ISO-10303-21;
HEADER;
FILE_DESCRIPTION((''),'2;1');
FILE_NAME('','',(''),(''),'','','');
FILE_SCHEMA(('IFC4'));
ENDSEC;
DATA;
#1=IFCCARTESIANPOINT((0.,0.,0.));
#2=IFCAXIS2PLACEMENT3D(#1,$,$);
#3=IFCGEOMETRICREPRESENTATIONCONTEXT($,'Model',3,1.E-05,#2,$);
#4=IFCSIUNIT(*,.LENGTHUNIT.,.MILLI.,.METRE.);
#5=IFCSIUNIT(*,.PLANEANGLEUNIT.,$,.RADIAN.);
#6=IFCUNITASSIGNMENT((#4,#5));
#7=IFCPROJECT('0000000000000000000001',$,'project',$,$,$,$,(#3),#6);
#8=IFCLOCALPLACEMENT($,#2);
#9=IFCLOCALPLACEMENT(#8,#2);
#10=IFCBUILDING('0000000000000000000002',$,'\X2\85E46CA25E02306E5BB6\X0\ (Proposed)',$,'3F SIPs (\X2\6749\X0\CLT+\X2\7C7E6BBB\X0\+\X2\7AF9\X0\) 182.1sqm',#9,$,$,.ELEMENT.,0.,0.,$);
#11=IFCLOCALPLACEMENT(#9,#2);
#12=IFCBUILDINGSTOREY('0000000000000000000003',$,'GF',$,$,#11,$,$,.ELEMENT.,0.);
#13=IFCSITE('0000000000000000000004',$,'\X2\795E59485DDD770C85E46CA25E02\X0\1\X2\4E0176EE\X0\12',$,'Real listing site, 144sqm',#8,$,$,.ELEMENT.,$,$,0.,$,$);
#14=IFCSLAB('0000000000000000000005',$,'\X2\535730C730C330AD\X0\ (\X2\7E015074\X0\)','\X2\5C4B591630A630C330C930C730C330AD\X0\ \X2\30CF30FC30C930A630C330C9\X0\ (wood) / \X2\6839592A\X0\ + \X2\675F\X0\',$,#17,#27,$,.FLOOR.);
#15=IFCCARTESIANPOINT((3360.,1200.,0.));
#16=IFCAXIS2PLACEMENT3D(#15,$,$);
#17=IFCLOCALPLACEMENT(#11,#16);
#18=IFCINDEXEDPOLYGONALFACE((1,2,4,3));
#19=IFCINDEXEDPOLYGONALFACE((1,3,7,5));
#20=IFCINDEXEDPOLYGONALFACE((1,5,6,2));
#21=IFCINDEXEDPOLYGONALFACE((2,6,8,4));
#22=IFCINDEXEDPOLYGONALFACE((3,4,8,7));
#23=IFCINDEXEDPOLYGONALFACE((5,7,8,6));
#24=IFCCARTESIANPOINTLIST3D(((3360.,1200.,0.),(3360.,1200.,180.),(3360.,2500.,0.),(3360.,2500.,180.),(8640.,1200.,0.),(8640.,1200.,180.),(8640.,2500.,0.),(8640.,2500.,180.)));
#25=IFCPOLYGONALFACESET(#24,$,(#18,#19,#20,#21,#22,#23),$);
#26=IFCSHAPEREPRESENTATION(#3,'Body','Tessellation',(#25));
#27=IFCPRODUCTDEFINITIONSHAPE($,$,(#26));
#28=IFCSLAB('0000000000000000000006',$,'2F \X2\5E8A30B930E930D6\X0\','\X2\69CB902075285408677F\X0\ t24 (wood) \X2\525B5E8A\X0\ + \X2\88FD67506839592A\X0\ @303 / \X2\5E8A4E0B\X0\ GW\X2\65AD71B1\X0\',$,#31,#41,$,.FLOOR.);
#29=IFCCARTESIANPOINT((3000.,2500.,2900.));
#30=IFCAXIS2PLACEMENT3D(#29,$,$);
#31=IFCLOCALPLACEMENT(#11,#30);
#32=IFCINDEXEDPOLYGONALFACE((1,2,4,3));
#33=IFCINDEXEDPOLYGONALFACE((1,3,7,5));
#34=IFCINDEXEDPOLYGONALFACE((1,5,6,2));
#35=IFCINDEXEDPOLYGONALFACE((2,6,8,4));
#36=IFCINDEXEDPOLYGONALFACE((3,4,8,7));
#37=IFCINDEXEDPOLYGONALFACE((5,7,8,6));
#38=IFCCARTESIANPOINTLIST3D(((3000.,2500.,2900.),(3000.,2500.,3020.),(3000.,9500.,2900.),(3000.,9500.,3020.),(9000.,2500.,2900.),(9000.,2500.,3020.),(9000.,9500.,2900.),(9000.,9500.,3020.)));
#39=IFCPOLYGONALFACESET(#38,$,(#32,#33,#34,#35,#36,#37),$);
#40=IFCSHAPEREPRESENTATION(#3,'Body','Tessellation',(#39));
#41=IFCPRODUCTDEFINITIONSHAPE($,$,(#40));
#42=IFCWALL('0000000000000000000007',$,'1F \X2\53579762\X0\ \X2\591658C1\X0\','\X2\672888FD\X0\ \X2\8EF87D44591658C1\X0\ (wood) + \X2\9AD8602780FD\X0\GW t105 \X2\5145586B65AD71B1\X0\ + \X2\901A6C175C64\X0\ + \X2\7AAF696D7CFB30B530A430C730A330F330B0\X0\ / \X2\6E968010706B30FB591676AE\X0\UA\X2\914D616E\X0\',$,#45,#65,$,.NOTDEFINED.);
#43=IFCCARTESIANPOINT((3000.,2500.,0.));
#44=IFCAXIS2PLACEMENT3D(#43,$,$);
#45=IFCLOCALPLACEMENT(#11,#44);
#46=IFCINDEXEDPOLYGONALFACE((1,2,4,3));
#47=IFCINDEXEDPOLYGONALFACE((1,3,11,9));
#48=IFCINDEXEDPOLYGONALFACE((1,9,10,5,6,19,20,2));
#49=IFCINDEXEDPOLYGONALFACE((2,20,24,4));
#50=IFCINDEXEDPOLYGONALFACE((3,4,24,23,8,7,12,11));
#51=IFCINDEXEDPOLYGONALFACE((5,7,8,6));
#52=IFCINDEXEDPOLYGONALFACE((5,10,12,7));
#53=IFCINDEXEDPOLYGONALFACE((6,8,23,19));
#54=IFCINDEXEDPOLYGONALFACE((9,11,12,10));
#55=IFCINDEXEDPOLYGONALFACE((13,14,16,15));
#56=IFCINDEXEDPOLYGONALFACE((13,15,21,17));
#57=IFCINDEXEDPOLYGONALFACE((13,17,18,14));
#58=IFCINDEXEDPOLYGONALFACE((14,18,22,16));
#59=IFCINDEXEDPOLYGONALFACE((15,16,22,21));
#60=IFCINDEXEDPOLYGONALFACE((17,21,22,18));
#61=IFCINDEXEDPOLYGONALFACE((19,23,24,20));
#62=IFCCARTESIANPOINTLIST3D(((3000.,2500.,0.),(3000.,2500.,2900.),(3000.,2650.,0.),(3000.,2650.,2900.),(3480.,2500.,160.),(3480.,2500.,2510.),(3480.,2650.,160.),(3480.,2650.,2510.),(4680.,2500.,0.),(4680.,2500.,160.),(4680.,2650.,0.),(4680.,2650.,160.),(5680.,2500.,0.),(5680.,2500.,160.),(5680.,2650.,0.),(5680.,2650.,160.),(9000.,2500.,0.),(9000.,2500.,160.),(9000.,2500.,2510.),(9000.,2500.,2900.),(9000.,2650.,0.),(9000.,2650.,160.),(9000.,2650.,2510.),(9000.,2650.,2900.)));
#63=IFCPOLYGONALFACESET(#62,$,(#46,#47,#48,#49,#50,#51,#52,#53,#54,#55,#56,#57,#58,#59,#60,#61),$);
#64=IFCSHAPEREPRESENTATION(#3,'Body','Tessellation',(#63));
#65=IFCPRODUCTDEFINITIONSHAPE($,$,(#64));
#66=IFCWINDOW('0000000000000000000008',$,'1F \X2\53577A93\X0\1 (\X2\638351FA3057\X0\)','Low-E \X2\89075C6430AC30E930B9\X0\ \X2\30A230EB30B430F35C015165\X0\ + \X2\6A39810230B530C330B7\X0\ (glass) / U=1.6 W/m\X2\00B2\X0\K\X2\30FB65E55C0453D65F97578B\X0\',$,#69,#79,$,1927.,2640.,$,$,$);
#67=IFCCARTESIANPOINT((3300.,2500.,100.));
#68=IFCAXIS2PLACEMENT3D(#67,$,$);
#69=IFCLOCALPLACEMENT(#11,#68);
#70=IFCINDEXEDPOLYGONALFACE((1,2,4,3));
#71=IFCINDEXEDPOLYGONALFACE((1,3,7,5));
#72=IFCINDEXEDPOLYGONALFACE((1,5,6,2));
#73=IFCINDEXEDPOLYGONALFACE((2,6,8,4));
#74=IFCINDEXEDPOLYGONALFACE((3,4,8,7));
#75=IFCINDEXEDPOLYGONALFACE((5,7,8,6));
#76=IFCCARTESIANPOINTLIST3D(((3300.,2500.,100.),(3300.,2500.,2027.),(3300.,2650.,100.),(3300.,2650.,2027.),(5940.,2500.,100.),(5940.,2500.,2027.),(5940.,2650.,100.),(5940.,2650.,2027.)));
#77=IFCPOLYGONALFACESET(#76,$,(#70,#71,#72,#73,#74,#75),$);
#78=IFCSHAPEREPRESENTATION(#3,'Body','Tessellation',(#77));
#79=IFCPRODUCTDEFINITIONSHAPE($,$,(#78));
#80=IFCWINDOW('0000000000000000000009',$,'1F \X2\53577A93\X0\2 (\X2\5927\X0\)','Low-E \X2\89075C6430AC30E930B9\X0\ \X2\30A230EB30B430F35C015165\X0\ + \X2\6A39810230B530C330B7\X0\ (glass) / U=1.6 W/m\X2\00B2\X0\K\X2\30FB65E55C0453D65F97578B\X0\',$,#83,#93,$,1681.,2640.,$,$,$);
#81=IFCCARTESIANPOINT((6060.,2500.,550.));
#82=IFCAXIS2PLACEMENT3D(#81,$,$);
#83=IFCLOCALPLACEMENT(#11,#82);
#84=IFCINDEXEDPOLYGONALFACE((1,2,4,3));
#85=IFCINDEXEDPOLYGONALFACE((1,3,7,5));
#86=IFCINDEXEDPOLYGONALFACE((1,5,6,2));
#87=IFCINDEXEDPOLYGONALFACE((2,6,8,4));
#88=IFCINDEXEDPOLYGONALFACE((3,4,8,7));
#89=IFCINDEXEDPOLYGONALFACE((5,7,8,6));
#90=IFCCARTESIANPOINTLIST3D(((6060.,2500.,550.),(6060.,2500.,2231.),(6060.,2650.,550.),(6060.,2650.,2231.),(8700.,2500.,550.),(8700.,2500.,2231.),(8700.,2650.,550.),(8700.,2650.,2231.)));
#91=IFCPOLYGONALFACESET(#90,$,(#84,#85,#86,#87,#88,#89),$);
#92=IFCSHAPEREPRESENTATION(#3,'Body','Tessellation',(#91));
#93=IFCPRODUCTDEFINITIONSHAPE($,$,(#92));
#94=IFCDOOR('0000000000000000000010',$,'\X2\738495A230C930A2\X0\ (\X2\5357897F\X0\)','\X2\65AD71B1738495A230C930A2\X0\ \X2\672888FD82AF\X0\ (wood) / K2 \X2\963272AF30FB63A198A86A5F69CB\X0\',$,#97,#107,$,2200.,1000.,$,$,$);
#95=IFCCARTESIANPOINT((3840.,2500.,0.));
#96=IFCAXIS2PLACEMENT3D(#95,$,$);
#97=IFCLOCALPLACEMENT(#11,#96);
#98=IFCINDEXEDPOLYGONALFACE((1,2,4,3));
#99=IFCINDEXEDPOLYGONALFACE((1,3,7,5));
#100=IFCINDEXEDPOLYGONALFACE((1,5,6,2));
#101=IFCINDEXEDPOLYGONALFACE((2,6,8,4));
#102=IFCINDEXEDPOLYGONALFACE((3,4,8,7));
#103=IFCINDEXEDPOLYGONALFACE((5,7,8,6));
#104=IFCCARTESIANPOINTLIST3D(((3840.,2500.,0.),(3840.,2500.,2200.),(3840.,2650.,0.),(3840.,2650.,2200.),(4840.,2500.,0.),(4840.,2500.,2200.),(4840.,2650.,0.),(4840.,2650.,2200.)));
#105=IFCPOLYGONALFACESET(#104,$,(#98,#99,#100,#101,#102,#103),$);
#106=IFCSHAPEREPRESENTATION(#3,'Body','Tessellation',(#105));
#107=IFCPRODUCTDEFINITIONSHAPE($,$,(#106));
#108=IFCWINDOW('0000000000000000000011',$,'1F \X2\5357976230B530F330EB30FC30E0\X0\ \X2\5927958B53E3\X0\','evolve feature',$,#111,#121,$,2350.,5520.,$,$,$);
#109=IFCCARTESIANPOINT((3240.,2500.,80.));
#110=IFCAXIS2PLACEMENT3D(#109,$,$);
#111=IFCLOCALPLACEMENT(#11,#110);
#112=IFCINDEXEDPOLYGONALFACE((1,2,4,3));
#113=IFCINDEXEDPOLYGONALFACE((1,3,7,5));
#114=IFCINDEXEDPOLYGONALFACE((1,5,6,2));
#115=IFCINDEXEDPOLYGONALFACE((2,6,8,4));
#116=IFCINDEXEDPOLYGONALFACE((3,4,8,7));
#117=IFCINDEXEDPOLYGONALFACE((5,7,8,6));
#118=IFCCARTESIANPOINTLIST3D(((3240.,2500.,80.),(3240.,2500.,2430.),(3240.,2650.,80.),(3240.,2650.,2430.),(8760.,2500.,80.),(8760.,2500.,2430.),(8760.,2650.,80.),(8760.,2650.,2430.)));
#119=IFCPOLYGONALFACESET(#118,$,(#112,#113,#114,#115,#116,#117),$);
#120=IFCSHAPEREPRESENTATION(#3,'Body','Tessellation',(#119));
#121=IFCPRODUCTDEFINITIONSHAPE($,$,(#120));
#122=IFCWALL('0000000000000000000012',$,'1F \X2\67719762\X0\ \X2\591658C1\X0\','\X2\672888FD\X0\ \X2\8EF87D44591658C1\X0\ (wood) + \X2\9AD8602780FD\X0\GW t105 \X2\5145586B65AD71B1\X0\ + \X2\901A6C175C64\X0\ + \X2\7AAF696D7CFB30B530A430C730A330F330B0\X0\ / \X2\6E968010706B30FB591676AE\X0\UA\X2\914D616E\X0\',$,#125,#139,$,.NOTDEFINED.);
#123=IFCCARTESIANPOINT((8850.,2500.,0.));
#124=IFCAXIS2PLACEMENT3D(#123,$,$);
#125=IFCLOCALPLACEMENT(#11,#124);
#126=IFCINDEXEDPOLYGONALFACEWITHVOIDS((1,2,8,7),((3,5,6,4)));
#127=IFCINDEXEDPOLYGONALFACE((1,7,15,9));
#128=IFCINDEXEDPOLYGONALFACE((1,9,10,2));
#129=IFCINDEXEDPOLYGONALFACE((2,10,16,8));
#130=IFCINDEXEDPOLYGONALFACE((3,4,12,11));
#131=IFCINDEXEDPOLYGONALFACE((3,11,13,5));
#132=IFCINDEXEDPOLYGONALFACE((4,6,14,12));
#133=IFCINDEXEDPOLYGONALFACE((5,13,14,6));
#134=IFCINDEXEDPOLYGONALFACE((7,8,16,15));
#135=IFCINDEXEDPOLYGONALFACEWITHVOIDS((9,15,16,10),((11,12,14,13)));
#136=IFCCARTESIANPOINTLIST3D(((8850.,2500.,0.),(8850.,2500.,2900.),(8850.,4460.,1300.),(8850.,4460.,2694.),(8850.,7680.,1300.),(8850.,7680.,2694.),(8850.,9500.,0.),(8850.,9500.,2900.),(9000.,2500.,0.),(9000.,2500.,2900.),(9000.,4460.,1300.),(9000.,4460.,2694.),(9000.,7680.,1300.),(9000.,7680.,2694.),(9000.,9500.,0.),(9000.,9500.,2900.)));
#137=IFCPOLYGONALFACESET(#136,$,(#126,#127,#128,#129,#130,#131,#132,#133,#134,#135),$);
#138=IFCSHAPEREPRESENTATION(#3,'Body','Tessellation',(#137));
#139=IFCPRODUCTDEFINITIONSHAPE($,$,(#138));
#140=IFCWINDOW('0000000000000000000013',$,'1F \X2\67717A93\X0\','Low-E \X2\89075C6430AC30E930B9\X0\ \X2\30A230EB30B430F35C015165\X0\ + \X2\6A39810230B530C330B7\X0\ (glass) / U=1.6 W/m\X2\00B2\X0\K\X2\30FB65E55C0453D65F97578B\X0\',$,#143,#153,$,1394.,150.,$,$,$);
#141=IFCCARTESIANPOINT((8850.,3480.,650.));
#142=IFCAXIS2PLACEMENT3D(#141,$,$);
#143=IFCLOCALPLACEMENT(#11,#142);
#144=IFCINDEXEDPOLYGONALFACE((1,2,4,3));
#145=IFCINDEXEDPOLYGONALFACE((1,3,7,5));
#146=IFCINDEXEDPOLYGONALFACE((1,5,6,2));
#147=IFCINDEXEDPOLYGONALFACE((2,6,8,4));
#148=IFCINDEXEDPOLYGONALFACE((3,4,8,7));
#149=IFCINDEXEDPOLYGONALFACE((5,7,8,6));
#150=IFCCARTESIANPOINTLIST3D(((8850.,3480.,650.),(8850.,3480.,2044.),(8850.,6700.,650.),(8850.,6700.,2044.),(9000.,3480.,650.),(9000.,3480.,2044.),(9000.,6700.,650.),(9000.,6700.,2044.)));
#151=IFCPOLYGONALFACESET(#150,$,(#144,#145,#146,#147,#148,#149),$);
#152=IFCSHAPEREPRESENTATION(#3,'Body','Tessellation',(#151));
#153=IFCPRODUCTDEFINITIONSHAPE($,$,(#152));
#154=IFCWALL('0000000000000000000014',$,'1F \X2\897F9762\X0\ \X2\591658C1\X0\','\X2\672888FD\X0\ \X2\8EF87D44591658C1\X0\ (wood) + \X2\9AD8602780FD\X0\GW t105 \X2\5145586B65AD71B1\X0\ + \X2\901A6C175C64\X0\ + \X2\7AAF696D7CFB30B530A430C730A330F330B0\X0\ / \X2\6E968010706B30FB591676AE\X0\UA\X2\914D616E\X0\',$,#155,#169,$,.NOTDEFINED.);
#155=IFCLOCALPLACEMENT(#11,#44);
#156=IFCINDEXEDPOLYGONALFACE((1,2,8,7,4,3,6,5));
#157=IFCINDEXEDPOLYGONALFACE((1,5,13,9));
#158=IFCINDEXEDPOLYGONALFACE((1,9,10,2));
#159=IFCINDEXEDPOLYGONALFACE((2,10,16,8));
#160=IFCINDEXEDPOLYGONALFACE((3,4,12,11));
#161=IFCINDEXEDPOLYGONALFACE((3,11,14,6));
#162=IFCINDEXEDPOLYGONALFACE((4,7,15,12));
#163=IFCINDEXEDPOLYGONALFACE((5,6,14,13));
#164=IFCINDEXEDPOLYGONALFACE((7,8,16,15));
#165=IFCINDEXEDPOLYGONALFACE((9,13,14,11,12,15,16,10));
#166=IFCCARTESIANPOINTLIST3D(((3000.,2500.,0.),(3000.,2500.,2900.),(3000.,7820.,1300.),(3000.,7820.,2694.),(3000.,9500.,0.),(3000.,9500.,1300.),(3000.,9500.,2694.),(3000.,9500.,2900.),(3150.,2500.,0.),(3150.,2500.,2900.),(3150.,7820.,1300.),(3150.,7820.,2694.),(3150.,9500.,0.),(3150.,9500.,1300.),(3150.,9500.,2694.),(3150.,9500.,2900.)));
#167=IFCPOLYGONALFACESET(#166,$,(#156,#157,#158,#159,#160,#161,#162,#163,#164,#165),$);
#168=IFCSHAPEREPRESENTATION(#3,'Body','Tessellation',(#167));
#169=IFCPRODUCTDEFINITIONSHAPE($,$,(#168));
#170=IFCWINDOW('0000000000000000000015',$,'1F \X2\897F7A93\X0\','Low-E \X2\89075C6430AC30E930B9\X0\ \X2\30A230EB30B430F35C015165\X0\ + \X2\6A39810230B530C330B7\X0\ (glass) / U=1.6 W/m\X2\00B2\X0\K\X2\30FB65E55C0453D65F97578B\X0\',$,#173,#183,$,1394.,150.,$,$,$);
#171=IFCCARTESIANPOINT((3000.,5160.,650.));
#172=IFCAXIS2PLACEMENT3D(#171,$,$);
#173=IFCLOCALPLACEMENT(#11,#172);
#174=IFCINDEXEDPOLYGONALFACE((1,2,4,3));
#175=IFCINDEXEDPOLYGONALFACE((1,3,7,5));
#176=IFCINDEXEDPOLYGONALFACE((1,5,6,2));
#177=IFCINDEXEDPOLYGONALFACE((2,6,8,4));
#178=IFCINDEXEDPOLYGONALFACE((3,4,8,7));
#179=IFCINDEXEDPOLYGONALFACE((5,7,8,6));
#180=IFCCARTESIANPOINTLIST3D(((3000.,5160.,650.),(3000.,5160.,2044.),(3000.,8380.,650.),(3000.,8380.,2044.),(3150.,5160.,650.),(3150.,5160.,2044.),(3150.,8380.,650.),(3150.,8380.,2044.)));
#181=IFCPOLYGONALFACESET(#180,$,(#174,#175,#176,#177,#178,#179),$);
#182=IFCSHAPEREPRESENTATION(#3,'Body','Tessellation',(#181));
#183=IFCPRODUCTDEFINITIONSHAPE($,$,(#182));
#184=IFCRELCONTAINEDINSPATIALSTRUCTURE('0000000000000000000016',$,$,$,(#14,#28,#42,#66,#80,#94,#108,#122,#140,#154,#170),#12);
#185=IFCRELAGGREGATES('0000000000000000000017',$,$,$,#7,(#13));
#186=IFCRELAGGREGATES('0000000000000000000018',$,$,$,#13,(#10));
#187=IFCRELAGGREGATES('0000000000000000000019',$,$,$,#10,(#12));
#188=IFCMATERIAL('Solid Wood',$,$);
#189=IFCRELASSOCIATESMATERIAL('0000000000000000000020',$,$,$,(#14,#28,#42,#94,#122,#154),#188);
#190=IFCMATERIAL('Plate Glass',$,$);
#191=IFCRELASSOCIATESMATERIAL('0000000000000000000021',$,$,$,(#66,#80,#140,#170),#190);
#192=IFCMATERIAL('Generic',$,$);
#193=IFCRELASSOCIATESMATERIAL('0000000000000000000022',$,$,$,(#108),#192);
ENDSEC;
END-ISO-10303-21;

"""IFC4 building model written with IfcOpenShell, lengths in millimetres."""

from ifc_helpers import new_model, si_unit, frame, frame_2d, origin, place, context, project, spatial, rectangle, extrude, material, element, fill, save


model = new_model("IFC4")

# Units and contexts
model_context = context("Model", 3, precision=1e-05, world=origin())
ifc_project = project(units=[si_unit("LENGTHUNIT", "METRE", prefix="MILLI"), si_unit("PLANEANGLEUNIT", "RADIAN")], contexts=[model_context])

# Site, building, storey
site_placement = place(None, origin())
site = spatial("IfcSite", under=ifc_project, at=site_placement, Name="神奈川県藤沢市1丁目12", ObjectType="Real listing site, 144sqm", CompositionType="ELEMENT", RefElevation=0.0)
building_placement = place(site_placement, origin())
building = spatial("IfcBuilding", under=site, at=building_placement, Name="藤沢市の家 (Proposed)", ObjectType="3F SIPs (杉CLT+籾殻+竹) 182.1sqm", CompositionType="ELEMENT", ElevationOfRefHeight=0.0, ElevationOfTerrain=0.0)
storey_placement = place(building_placement, origin())
storey = spatial("IfcBuildingStorey", under=building, at=storey_placement, Name="GF", CompositionType="ELEMENT", Elevation=0.0)

# Slabs
ifc_material_1 = material(Name="Solid Wood")
slab_1_placement = place(storey_placement, frame((3360.0, 1200.0, 0.0)))
element("IfcSlab", 1, at=slab_1_placement, inside=storey, material=ifc_material_1, Name="南デッキ (縁側)", Description="屋外ウッドデッキ ハードウッド (wood) / 根太 + 束", PredefinedType="FLOOR", context=model_context, shape_type="SweptSolid", body=[
    extrude(rectangle(XDim=5280.0, YDim=1300.0, at=frame_2d((2640.0, 650.0))), frame((3360.0, 1200.0, 0.0)), (0.0, 0.0, 1.0), 180.0),
])
slab_2_placement = place(storey_placement, frame((3000.0, 2500.0, 2900.0)))
element("IfcSlab", 2, at=slab_2_placement, inside=storey, material=ifc_material_1, Name="2F 床スラブ", Description="構造用合板 t24 (wood) 剛床 + 製材根太 @303 / 床下 GW断熱", PredefinedType="FLOOR", context=model_context, shape_type="SweptSolid", body=[
    extrude(rectangle(XDim=6000.0, YDim=7000.0, at=frame_2d((3000.0, 3500.0))), frame((3000.0, 2500.0, 2900.0)), (0.0, 0.0, 1.0), 120.0),
])

# Wall, openings, windows, door
wall_1_placement = place(storey_placement, frame((3000.0, 2500.0, 0.0)))
wall_1 = element("IfcWall", 3, at=wall_1_placement, inside=storey, material=ifc_material_1, Name="1F 南面 外壁", Description="木製 軸組外壁 (wood) + 高性能GW t105 充填断熱 + 通気層 + 窯業系サイディング / 準耐火・外皮UA配慮", PredefinedType="NOTDEFINED", context=model_context, shape_type="SweptSolid", body=[
    extrude(rectangle(XDim=6000.0, YDim=150.0, at=frame_2d((3000.0, 75.0))), frame((3000.0, 2500.0, 0.0)), (0.0, 0.0, 1.0), 2900.0),
])
opening_1_placement = place(storey_placement, frame((3300.0, 2500.0, 100.0)))
opening_1 = element("IfcOpeningElement", 4, at=opening_1_placement, cuts=wall_1, PredefinedType="NOTDEFINED", context=model_context, shape_type="SweptSolid", body=[
    extrude(rectangle(XDim=2640.0, YDim=150.0, at=frame_2d((1320.0, 75.0))), frame((3300.0, 2500.0, 100.0)), (0.0, 0.0, 1.0), 1927.0),
])
opening_2_placement = place(storey_placement, frame((6060.0, 2500.0, 550.0)))
opening_2 = element("IfcOpeningElement", 5, at=opening_2_placement, cuts=wall_1, PredefinedType="NOTDEFINED", context=model_context, shape_type="SweptSolid", body=[
    extrude(rectangle(XDim=2640.0, YDim=150.0, at=frame_2d((1320.0, 75.0))), frame((6060.0, 2500.0, 550.0)), (0.0, 0.0, 1.0), 1681.0),
])
opening_3_placement = place(storey_placement, frame((3840.0, 2500.0, 0.0)))
opening_3 = element("IfcOpeningElement", 6, at=opening_3_placement, cuts=wall_1, PredefinedType="NOTDEFINED", context=model_context, shape_type="SweptSolid", body=[
    extrude(rectangle(XDim=1000.0, YDim=150.0, at=frame_2d((500.0, 75.0))), frame((3840.0, 2500.0, 0.0)), (0.0, 0.0, 1.0), 2200.0),
])
opening_4_placement = place(storey_placement, frame((3240.0, 2500.0, 80.0)))
opening_4 = element("IfcOpeningElement", 7, at=opening_4_placement, cuts=wall_1, PredefinedType="NOTDEFINED", context=model_context, shape_type="SweptSolid", body=[
    extrude(rectangle(XDim=5520.0, YDim=150.0, at=frame_2d((2760.0, 75.0))), frame((3240.0, 2500.0, 80.0)), (0.0, 0.0, 1.0), 2350.0),
])
ifc_material_2 = material(Name="Plate Glass")
window_1_placement = place(storey_placement, frame((3300.0, 2500.0, 100.0)))
window_1 = element("IfcWindow", 8, at=window_1_placement, inside=storey, material=ifc_material_2, Name="1F 南窓1 (掃出し)", Description="Low-E 複層ガラス アルゴン封入 + 樹脂サッシ (glass) / U=1.6 W/m²K・日射取得型", OverallHeight=1927.0, OverallWidth=2640.0, context=model_context, shape_type="SweptSolid", body=[
    extrude(rectangle(XDim=2640.0, YDim=150.0, at=frame_2d((1320.0, 75.0))), frame((3300.0, 2500.0, 100.0)), (0.0, 0.0, 1.0), 1927.0),
])
fill(opening_1, window_1)
window_2_placement = place(storey_placement, frame((6060.0, 2500.0, 550.0)))
window_2 = element("IfcWindow", 9, at=window_2_placement, inside=storey, material=ifc_material_2, Name="1F 南窓2 (大)", Description="Low-E 複層ガラス アルゴン封入 + 樹脂サッシ (glass) / U=1.6 W/m²K・日射取得型", OverallHeight=1681.0, OverallWidth=2640.0, context=model_context, shape_type="SweptSolid", body=[
    extrude(rectangle(XDim=2640.0, YDim=150.0, at=frame_2d((1320.0, 75.0))), frame((6060.0, 2500.0, 550.0)), (0.0, 0.0, 1.0), 1681.0),
])
fill(opening_2, window_2)
door_placement = place(storey_placement, frame((3840.0, 2500.0, 0.0)))
door = element("IfcDoor", 10, at=door_placement, inside=storey, material=ifc_material_1, Name="玄関ドア (南西)", Description="断熱玄関ドア 木製芯 (wood) / K2 防犯・採風機構", OverallHeight=2200.0, OverallWidth=1000.0, context=model_context, shape_type="SweptSolid", body=[
    extrude(rectangle(XDim=1000.0, YDim=150.0, at=frame_2d((500.0, 75.0))), frame((3840.0, 2500.0, 0.0)), (0.0, 0.0, 1.0), 2200.0),
])
fill(opening_3, door)
ifc_material_3 = material(Name="Generic")
window_3_placement = place(storey_placement, frame((3240.0, 2500.0, 80.0)))
window_3 = element("IfcWindow", 11, at=window_3_placement, inside=storey, material=ifc_material_3, Name="1F 南面サンルーム 大開口", Description="evolve feature", OverallHeight=2350.0, OverallWidth=5520.0, context=model_context, shape_type="SweptSolid", body=[
    extrude(rectangle(XDim=5520.0, YDim=150.0, at=frame_2d((2760.0, 75.0))), frame((3240.0, 2500.0, 80.0)), (0.0, 0.0, 1.0), 2350.0),
])
fill(opening_4, window_3)

# Walls, openings, windows
wall_2_placement = place(storey_placement, frame((8850.0, 2500.0, 0.0)))
wall_2 = element("IfcWall", 12, at=wall_2_placement, inside=storey, material=ifc_material_1, Name="1F 東面 外壁", Description="木製 軸組外壁 (wood) + 高性能GW t105 充填断熱 + 通気層 + 窯業系サイディング / 準耐火・外皮UA配慮", PredefinedType="NOTDEFINED", context=model_context, shape_type="SweptSolid", body=[
    extrude(rectangle(XDim=150.0, YDim=7000.0, at=frame_2d((75.0, 3500.0))), frame((8850.0, 2500.0, 0.0)), (0.0, 0.0, 1.0), 2900.0),
])
opening_5_placement = place(storey_placement, frame((8850.0, 3480.0, 650.0)))
opening_5 = element("IfcOpeningElement", 13, at=opening_5_placement, cuts=wall_2, PredefinedType="NOTDEFINED", context=model_context, shape_type="SweptSolid", body=[
    extrude(rectangle(XDim=150.0, YDim=3220.0, at=frame_2d((75.0, 1610.0))), frame((8850.0, 3480.0, 650.0)), (0.0, 0.0, 1.0), 1394.0),
])
window_4_placement = place(storey_placement, frame((8850.0, 3480.0, 650.0)))
window_4 = element("IfcWindow", 14, at=window_4_placement, inside=storey, material=ifc_material_2, Name="1F 東窓", Description="Low-E 複層ガラス アルゴン封入 + 樹脂サッシ (glass) / U=1.6 W/m²K・日射取得型", OverallHeight=1394.0, OverallWidth=150.0, context=model_context, shape_type="SweptSolid", body=[
    extrude(rectangle(XDim=150.0, YDim=3220.0, at=frame_2d((75.0, 1610.0))), frame((8850.0, 3480.0, 650.0)), (0.0, 0.0, 1.0), 1394.0),
])
fill(opening_5, window_4)
wall_3_placement = place(storey_placement, frame((3000.0, 2500.0, 0.0)))
wall_3 = element("IfcWall", 15, at=wall_3_placement, inside=storey, material=ifc_material_1, Name="1F 西面 外壁", Description="木製 軸組外壁 (wood) + 高性能GW t105 充填断熱 + 通気層 + 窯業系サイディング / 準耐火・外皮UA配慮", PredefinedType="NOTDEFINED", context=model_context, shape_type="SweptSolid", body=[
    extrude(rectangle(XDim=150.0, YDim=7000.0, at=frame_2d((75.0, 3500.0))), frame((3000.0, 2500.0, 0.0)), (0.0, 0.0, 1.0), 2900.0),
])
opening_6_placement = place(storey_placement, frame((3000.0, 5160.0, 650.0)))
opening_6 = element("IfcOpeningElement", 16, at=opening_6_placement, cuts=wall_3, PredefinedType="NOTDEFINED", context=model_context, shape_type="SweptSolid", body=[
    extrude(rectangle(XDim=150.0, YDim=3220.0, at=frame_2d((75.0, 1610.0))), frame((3000.0, 5160.0, 650.0)), (0.0, 0.0, 1.0), 1394.0),
])
window_5_placement = place(storey_placement, frame((3000.0, 5160.0, 650.0)))
window_5 = element("IfcWindow", 17, at=window_5_placement, inside=storey, material=ifc_material_2, Name="1F 西窓", Description="Low-E 複層ガラス アルゴン封入 + 樹脂サッシ (glass) / U=1.6 W/m²K・日射取得型", OverallHeight=1394.0, OverallWidth=150.0, context=model_context, shape_type="SweptSolid", body=[
    extrude(rectangle(XDim=150.0, YDim=3220.0, at=frame_2d((75.0, 1610.0))), frame((3000.0, 5160.0, 650.0)), (0.0, 0.0, 1.0), 1394.0),
])
fill(opening_6, window_5)

save(model, "model.ifc")
